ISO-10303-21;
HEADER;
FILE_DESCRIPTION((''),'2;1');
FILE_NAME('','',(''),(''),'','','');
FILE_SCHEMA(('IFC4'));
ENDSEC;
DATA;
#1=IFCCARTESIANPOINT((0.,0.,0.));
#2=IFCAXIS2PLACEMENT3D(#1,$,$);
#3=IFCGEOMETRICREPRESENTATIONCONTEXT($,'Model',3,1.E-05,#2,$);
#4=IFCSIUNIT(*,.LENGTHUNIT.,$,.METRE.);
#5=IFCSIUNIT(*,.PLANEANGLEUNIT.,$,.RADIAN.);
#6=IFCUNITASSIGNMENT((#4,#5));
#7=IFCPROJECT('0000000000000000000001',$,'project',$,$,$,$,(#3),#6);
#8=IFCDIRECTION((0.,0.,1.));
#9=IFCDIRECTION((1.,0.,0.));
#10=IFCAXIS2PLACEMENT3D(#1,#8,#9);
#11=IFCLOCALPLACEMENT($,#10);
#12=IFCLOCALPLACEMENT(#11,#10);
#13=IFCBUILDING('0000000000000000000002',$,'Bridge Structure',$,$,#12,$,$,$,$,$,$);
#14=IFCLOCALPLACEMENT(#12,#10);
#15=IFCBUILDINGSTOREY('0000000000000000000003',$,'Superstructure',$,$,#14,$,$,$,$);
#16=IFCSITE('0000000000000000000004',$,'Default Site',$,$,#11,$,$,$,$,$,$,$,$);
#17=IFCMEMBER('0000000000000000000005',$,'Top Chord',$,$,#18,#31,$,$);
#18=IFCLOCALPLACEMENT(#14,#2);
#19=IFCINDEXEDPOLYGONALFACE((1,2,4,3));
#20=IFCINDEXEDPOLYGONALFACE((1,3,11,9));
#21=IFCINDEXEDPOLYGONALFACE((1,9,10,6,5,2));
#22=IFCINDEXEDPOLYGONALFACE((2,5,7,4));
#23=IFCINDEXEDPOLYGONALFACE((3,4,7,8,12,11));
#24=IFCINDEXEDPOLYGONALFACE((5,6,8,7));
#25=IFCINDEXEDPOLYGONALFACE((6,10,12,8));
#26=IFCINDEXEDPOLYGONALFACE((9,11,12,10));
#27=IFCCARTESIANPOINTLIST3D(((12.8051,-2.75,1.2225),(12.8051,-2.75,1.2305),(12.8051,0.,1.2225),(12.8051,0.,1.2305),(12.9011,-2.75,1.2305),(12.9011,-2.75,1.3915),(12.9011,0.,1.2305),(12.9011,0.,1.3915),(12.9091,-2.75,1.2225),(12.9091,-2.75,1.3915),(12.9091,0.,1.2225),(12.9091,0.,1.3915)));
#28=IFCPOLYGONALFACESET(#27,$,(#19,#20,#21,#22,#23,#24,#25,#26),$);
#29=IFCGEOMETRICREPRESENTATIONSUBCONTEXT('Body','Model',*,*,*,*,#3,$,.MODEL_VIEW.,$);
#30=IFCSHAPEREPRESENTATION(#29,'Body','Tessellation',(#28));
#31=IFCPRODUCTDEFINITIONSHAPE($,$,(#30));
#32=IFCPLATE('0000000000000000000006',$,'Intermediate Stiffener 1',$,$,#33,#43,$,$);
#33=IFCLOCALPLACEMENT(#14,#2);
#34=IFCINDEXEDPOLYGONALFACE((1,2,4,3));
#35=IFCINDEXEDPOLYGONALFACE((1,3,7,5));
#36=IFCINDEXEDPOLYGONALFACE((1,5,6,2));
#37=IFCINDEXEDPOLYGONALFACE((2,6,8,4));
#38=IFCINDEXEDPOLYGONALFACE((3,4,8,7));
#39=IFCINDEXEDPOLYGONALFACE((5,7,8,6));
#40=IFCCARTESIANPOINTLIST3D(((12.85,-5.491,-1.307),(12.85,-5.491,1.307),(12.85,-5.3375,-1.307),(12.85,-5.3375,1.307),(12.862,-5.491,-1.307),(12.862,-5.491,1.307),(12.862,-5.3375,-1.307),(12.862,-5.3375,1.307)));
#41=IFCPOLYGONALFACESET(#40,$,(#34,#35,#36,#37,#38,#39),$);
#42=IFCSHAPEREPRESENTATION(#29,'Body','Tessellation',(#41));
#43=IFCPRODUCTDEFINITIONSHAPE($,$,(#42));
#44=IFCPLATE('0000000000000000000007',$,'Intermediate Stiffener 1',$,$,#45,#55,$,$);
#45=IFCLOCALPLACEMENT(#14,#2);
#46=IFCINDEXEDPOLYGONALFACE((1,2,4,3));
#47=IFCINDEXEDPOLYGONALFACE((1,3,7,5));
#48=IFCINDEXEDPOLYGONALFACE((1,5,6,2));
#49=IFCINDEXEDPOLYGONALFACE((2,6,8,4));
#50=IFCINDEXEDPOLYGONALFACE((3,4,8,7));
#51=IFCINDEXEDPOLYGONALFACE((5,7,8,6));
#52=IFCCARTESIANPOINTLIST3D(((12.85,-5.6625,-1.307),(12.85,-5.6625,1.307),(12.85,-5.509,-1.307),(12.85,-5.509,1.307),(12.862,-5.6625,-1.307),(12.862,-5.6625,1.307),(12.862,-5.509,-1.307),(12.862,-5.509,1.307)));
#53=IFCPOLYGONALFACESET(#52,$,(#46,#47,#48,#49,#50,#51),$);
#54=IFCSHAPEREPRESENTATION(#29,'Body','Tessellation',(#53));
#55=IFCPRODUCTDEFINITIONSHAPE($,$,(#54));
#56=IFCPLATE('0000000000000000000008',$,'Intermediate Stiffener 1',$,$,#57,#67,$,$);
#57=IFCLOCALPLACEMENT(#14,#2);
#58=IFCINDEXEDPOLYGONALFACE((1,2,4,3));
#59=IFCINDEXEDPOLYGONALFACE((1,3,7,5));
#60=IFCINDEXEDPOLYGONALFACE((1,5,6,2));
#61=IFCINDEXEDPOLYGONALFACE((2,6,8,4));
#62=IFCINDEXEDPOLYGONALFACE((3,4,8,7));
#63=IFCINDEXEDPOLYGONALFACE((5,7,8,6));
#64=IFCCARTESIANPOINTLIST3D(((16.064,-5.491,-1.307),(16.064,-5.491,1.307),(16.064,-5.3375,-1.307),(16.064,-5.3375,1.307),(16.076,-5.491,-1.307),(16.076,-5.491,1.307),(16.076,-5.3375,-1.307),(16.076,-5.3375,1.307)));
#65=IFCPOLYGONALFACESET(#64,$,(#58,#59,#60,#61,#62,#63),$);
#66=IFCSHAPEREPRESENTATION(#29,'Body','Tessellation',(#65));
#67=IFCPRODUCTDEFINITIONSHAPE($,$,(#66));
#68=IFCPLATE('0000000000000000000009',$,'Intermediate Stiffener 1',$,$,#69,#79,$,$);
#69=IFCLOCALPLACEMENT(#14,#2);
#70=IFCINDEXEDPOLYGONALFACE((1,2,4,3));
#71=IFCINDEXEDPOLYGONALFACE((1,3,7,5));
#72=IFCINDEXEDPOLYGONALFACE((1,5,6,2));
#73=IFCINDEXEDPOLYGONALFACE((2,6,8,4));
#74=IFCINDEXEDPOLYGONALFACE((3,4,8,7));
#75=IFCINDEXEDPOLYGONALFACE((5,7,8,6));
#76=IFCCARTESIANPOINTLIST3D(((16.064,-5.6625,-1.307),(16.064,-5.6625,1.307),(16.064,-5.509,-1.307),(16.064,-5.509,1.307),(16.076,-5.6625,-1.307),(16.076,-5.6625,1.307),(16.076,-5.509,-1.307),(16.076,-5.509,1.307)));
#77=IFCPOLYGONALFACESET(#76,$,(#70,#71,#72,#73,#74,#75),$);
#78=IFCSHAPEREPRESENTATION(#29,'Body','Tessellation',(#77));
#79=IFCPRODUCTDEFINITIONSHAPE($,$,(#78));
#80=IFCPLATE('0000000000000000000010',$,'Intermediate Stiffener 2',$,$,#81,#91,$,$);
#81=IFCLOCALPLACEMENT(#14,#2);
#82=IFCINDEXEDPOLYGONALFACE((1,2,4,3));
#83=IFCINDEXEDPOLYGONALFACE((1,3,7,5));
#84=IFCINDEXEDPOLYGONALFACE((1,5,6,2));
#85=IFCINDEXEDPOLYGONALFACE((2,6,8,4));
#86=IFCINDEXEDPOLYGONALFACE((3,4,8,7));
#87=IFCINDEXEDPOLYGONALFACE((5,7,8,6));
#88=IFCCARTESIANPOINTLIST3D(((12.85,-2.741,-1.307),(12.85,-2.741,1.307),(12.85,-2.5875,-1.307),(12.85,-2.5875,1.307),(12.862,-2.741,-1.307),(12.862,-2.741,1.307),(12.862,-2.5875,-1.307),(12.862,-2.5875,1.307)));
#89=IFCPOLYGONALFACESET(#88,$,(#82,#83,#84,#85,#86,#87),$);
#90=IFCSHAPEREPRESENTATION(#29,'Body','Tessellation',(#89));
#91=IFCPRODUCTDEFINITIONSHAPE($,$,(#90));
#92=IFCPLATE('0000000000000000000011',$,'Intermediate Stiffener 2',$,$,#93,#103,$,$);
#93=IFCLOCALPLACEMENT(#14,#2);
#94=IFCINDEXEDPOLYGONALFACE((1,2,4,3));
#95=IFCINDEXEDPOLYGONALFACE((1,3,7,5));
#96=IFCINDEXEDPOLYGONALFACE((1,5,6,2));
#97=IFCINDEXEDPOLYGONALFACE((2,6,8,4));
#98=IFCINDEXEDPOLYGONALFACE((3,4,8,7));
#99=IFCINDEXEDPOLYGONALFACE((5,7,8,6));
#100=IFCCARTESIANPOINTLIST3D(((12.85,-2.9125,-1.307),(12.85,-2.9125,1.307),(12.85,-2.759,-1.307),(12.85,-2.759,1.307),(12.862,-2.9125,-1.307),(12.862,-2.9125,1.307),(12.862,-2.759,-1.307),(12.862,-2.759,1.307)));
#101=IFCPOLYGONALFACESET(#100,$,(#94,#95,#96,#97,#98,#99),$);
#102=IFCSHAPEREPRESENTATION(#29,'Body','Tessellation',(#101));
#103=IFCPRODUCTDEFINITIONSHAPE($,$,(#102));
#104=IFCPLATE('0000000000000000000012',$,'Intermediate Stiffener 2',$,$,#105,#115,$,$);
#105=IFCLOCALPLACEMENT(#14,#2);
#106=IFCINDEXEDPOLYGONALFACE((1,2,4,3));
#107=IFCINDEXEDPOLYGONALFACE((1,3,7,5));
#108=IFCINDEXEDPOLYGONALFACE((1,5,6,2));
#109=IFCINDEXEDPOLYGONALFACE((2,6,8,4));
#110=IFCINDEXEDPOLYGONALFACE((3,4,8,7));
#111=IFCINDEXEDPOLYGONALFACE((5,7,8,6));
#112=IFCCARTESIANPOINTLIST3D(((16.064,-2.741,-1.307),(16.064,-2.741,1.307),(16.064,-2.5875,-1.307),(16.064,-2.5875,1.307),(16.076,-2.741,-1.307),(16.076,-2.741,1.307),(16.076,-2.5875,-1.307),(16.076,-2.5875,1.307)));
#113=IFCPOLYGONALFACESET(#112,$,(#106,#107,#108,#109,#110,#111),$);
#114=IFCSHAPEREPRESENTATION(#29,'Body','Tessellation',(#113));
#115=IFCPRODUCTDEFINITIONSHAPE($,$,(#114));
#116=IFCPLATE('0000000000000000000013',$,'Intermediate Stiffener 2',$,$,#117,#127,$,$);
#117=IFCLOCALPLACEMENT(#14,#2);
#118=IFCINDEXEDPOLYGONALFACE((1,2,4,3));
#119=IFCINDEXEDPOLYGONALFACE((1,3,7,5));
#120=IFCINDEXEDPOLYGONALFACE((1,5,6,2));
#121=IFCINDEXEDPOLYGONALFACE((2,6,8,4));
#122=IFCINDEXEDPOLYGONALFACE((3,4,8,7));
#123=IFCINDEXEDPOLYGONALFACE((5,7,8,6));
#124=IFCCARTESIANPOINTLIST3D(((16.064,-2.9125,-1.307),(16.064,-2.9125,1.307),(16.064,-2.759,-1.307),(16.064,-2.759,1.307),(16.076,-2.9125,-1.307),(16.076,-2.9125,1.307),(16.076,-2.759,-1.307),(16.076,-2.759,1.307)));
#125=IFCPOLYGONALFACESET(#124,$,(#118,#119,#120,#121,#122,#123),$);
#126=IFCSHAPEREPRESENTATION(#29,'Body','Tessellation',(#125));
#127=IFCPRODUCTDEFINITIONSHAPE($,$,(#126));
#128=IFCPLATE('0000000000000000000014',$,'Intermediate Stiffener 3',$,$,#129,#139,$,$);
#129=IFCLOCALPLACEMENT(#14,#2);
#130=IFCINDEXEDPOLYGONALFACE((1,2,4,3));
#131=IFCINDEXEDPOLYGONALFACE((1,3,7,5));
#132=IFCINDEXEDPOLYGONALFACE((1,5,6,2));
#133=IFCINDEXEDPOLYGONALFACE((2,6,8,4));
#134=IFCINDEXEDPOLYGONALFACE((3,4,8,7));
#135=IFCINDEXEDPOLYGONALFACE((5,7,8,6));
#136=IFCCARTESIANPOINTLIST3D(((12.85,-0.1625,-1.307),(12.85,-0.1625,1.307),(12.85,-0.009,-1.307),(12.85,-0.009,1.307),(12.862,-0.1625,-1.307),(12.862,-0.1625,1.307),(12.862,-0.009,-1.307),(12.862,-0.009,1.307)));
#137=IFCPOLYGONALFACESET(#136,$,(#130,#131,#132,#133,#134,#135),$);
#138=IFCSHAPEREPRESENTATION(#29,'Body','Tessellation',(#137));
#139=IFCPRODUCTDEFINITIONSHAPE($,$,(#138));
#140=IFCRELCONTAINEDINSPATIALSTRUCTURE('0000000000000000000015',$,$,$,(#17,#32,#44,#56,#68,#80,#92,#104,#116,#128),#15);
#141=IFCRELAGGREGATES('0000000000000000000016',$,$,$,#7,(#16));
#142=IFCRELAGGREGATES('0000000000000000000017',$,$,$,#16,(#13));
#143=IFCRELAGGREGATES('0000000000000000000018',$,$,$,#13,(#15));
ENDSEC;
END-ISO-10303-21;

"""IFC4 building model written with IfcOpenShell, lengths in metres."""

from ifc_helpers import new_model, si_unit, frame, origin, origin_with_axes, origin_2d_with_axis, place, context, subcontext, project, spatial, rectangle, l_section, extrude, element, save


model = new_model("IFC4")

# Units and contexts
model_context = context("Model", 3, precision=1e-05, world=origin())
body_context = subcontext(model_context, "Body", "Model", "MODEL_VIEW")
ifc_project = project(units=[si_unit("LENGTHUNIT", "METRE"), si_unit("PLANEANGLEUNIT", "RADIAN")], contexts=[model_context])

# Site, building, storey
site_placement = place(None, origin_with_axes())
site = spatial("IfcSite", under=ifc_project, at=site_placement, Name="Default Site")
building_placement = place(site_placement, origin_with_axes())
building = spatial("IfcBuilding", under=site, at=building_placement, Name="Bridge Structure")
storey_placement = place(building_placement, origin_with_axes())
storey = spatial("IfcBuildingStorey", under=building, at=storey_placement, Name="Superstructure")

# Member
for number, where, z_axis, x_axis, name in (
    (1, (12.8571, -2.75, 1.307), (0.0, 1.0, 0.0), (-1.0, 0.0, 0.0), "Top Chord"),
):
    element("IfcMember", number, at=place(storey_placement, frame(where, z_axis=z_axis, x_axis=x_axis)), inside=storey, Name=name, context=body_context, shape_type="SweptSolid", body=[
        extrude(l_section(Depth=0.169, Width=0.104, Thickness=0.008, at=origin_2d_with_axis()), origin_with_axes(), (0.0, 0.0, 1.0), 2.75),
    ])

# Plates
for number, where, z_axis, x_axis, name in (
    (2, (12.856, -5.4143, -1.307), (0.0, 0.0, 1.0), (1.0, 0.0, 0.0), "Intermediate Stiffener 1"),
    (3, (12.856, -5.5857, -1.307), (0.0, 0.0, 1.0), (1.0, 0.0, 0.0), "Intermediate Stiffener 1"),
    (4, (16.07, -5.4143, -1.307), (0.0, 0.0, 1.0), (1.0, 0.0, 0.0), "Intermediate Stiffener 1"),
    (5, (16.07, -5.5857, -1.307), (0.0, 0.0, 1.0), (1.0, 0.0, 0.0), "Intermediate Stiffener 1"),
    (6, (12.856, -2.6643, -1.307), (0.0, 0.0, 1.0), (1.0, 0.0, 0.0), "Intermediate Stiffener 2"),
    (7, (12.856, -2.8357, -1.307), (0.0, 0.0, 1.0), (1.0, 0.0, 0.0), "Intermediate Stiffener 2"),
    (8, (16.07, -2.6643, -1.307), (0.0, 0.0, 1.0), (1.0, 0.0, 0.0), "Intermediate Stiffener 2"),
    (9, (16.07, -2.8357, -1.307), (0.0, 0.0, 1.0), (1.0, 0.0, 0.0), "Intermediate Stiffener 2"),
    (10, (12.856, -0.0858, -1.307), (0.0, 0.0, 1.0), (1.0, 0.0, 0.0), "Intermediate Stiffener 3"),
):
    element("IfcPlate", number, at=place(storey_placement, frame(where, z_axis=z_axis, x_axis=x_axis)), inside=storey, Name=name, context=body_context, shape_type="SweptSolid", body=[
        extrude(rectangle(XDim=0.012, YDim=0.1535, at=origin_2d_with_axis()), origin_with_axes(), (0.0, 0.0, 1.0), 2.614),
    ])

save(model, "model.ifc")
